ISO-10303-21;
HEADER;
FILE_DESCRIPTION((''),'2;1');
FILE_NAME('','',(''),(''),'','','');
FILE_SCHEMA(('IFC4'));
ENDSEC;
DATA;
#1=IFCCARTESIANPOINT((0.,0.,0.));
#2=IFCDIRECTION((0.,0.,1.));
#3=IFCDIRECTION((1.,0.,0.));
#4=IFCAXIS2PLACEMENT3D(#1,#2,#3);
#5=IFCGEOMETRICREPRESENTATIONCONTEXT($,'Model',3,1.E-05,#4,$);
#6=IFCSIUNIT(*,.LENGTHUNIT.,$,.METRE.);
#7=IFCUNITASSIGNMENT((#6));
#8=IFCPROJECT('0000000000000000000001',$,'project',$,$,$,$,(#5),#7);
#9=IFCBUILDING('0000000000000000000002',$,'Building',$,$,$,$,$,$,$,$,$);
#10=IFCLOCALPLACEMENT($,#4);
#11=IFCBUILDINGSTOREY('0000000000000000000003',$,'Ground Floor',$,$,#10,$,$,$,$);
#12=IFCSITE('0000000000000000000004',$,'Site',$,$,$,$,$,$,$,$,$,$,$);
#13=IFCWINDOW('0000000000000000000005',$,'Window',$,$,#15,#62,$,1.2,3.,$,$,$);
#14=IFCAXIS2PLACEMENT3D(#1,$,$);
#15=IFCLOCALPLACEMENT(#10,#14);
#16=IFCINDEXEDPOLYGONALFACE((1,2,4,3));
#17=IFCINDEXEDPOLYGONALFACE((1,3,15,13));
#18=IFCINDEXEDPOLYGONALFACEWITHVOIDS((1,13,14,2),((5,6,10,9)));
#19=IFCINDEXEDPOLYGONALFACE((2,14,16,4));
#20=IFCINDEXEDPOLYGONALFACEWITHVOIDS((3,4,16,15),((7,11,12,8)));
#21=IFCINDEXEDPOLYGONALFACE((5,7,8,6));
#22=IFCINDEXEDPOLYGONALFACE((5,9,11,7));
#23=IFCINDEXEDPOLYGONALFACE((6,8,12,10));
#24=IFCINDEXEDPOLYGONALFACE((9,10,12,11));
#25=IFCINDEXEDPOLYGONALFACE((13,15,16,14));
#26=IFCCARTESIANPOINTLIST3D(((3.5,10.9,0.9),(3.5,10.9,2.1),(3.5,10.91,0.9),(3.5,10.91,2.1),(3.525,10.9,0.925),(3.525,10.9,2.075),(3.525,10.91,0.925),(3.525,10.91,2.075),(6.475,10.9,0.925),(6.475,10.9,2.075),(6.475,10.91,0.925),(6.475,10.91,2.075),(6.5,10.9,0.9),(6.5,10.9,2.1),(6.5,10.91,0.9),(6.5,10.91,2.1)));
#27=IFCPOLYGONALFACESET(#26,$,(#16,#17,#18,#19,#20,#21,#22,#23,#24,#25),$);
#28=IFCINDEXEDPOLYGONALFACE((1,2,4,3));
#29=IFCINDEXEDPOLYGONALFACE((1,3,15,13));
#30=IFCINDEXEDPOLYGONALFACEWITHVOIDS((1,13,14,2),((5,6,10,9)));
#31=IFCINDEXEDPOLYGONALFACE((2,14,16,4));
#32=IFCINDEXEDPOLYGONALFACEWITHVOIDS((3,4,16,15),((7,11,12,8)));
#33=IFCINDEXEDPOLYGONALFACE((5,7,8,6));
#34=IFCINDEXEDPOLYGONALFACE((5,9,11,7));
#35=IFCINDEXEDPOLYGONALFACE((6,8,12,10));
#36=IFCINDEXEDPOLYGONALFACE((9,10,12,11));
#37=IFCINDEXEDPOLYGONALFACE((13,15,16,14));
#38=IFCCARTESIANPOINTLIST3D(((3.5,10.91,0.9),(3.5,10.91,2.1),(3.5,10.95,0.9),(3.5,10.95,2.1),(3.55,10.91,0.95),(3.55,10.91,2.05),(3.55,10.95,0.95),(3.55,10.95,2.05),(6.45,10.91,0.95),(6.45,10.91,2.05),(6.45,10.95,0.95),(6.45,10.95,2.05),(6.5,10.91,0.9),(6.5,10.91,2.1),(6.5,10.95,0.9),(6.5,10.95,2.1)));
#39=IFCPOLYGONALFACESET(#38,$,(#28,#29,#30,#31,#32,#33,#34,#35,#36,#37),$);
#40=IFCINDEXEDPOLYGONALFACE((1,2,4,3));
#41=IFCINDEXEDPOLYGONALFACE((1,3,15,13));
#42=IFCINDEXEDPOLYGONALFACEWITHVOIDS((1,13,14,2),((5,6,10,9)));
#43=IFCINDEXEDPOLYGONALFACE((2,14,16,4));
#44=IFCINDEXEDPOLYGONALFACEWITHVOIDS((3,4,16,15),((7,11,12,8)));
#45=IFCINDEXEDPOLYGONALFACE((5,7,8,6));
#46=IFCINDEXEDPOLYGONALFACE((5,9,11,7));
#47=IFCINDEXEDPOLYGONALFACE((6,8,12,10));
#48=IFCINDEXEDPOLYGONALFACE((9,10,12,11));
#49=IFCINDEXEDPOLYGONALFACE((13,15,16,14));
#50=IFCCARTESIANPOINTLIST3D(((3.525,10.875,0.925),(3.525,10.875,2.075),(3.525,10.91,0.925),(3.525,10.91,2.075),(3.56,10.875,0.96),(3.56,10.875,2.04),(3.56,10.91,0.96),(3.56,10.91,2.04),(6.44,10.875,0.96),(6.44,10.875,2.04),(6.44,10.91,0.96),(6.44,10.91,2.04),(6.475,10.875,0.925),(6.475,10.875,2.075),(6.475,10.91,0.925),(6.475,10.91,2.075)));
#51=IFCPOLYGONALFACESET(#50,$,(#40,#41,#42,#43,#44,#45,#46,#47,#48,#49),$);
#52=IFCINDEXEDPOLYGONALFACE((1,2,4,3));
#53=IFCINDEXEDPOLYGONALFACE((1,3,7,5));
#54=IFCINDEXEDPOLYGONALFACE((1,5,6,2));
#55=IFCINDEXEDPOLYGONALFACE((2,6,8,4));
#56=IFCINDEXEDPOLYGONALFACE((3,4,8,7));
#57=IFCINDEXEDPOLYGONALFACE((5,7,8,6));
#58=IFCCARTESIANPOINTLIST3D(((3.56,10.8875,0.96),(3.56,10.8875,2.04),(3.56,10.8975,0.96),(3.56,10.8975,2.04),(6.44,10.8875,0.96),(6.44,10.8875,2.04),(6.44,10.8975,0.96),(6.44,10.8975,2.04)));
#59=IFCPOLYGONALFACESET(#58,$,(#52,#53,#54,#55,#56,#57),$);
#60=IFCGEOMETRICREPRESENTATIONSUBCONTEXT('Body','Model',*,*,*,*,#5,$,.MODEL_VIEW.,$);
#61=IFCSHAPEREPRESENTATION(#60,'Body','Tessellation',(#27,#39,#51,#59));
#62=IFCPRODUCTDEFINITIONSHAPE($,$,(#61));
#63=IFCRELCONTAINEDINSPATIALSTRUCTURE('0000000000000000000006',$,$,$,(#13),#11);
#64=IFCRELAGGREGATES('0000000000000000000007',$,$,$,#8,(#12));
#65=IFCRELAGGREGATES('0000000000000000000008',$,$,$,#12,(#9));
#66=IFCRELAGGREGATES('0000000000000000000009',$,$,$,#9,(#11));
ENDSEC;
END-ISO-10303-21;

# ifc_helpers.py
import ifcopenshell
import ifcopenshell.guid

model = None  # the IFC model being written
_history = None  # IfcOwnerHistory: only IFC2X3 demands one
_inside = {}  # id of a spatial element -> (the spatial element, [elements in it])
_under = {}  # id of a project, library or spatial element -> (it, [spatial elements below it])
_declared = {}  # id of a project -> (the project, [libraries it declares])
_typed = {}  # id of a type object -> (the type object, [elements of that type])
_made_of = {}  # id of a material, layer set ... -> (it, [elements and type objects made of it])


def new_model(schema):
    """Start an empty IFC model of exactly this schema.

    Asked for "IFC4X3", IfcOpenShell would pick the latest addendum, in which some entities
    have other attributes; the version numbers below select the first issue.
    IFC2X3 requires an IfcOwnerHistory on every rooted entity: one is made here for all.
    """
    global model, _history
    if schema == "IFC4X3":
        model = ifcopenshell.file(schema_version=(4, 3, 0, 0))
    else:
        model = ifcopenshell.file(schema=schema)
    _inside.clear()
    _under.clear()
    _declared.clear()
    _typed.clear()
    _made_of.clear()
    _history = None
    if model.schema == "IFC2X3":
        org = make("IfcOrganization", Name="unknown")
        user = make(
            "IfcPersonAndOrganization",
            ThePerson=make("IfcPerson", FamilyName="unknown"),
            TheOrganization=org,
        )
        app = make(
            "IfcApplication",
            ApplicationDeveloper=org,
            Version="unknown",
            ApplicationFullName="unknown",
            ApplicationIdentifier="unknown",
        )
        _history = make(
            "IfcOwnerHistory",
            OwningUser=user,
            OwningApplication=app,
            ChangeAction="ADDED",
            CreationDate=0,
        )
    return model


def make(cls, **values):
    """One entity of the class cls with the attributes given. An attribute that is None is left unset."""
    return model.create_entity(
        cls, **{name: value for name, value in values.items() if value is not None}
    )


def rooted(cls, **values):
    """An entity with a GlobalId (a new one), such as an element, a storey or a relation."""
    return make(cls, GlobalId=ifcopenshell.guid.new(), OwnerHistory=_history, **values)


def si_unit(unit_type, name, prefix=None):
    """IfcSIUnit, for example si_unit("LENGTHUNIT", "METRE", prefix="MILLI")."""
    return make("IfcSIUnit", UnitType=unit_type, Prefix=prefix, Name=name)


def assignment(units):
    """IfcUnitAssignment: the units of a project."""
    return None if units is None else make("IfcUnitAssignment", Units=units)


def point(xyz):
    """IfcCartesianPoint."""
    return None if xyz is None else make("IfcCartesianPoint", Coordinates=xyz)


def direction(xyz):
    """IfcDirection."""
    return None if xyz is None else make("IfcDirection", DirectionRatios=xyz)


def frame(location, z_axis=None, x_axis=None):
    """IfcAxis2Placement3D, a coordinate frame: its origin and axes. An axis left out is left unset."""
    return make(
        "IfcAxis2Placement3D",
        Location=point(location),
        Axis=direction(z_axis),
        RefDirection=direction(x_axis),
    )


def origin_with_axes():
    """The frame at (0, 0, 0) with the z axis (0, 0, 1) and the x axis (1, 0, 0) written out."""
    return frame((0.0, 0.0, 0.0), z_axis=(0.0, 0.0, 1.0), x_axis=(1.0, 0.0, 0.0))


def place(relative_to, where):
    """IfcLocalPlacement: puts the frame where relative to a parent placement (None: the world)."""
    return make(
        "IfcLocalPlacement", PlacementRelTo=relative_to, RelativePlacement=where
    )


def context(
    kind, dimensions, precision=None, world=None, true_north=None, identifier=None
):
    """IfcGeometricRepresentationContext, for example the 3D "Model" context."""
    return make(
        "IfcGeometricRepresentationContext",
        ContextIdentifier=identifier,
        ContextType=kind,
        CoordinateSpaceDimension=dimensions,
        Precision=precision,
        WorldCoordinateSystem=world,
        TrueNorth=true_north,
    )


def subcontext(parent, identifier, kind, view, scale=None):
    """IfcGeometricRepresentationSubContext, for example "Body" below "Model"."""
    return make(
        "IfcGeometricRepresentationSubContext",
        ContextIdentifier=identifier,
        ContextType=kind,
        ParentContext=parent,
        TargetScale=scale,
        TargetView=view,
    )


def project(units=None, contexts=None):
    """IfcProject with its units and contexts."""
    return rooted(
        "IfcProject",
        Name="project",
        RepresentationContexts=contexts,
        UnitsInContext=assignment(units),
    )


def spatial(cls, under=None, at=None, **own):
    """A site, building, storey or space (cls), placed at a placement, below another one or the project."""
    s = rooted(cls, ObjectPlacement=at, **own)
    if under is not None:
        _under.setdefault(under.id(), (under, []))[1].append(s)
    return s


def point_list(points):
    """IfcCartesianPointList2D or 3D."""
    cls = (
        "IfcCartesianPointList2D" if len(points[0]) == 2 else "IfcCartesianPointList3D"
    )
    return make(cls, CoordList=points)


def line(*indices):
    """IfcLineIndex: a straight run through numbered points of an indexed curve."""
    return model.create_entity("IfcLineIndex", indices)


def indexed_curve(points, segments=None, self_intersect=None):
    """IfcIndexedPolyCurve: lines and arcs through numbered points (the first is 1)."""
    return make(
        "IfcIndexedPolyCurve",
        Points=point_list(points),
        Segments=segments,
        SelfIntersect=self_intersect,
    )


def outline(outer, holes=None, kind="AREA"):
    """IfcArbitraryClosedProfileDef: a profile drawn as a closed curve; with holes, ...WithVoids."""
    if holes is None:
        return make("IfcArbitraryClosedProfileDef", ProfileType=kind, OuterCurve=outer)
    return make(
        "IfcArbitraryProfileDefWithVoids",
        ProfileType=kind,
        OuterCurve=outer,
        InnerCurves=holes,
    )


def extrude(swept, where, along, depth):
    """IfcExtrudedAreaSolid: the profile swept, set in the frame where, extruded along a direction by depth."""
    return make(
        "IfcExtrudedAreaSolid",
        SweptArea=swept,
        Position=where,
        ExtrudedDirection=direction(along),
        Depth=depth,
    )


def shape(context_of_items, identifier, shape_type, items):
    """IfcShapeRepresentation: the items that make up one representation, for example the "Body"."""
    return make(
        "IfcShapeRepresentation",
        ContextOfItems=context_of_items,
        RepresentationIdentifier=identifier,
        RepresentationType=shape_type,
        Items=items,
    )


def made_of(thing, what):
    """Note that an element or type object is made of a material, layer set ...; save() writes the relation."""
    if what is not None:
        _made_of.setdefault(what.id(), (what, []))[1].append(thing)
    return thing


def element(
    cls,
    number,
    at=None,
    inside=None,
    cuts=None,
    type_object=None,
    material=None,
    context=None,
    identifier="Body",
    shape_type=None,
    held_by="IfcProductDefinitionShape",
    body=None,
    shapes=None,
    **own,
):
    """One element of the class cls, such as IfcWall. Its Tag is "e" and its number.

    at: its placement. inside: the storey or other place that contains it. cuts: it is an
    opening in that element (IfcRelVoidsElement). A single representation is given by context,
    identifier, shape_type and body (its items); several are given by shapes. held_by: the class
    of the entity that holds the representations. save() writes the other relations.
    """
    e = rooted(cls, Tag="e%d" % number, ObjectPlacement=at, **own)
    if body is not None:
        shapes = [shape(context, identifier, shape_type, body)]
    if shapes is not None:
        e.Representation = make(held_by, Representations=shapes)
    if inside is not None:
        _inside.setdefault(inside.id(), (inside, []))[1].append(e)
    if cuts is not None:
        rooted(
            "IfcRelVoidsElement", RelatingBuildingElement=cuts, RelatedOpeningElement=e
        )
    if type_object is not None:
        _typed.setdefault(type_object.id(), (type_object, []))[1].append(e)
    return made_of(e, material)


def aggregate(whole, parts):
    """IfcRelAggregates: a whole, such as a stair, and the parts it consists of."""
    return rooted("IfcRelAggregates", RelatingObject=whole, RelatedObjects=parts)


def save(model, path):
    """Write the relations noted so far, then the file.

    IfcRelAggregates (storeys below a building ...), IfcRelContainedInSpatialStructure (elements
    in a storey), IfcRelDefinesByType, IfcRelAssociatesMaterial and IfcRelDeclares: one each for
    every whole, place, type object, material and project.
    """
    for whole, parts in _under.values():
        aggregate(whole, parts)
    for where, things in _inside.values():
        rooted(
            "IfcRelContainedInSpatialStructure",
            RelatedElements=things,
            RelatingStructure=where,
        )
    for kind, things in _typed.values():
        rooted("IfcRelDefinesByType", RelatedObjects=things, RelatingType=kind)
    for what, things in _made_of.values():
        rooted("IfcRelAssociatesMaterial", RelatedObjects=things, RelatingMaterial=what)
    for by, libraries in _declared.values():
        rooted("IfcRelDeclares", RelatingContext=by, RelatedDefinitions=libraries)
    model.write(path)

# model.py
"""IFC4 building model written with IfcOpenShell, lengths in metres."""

from ifc_helpers import new_model, si_unit, frame, origin_with_axes, place, context, subcontext, project, spatial, line, indexed_curve, outline, extrude, element, save


model = new_model("IFC4")

# Units and contexts
model_context = context("Model", 3, precision=1e-05, world=origin_with_axes())
body_context = subcontext(model_context, "Body", "Model", "MODEL_VIEW")
ifc_project = project(units=[si_unit("LENGTHUNIT", "METRE")], contexts=[model_context])

# Site, building, storey
site = spatial("IfcSite", under=ifc_project, Name="Site")
building = spatial("IfcBuilding", under=site, Name="Building")
storey_placement = place(None, origin_with_axes())
storey = spatial("IfcBuildingStorey", under=building, at=storey_placement, Name="Ground Floor")

# Window
window_placement = place(storey_placement, frame((6.5, 11.0, 0.9), z_axis=(0.0, 0.0, 1.0), x_axis=(-1.0, 0.0, 0.0)))
element("IfcWindow", 1, at=window_placement, inside=storey, Name="Window", OverallHeight=1.2, OverallWidth=3.0, context=body_context, shape_type="SweptSolid", body=[
    extrude(outline(indexed_curve([(0.0, 0.0), (3.0, 0.0), (3.0, 1.2), (0.0, 1.2)], segments=[line(1, 2, 3, 4, 1)]), holes=[indexed_curve([(0.025, 0.025), (2.975, 0.025), (2.975, 1.175), (0.025, 1.175)], segments=[line(1, 2, 3, 4, 1)])]), frame((0.0, 0.09, 0.0), z_axis=(0.0, -1.0, 0.0), x_axis=(1.0, 0.0, 0.0)), (0.0, 0.0, -1.0), 0.01),
    extrude(outline(indexed_curve([(0.0, 0.0), (3.0, 0.0), (3.0, 1.2), (0.0, 1.2)], segments=[line(1, 2, 3, 4, 1)]), holes=[indexed_curve([(0.05, 0.05), (2.95, 0.05), (2.95, 1.15), (0.05, 1.15)], segments=[line(1, 2, 3, 4, 1)])]), frame((0.0, 0.05, 0.0), z_axis=(0.0, -1.0, 0.0), x_axis=(1.0, 0.0, 0.0)), (0.0, 0.0, -1.0), 0.04),
    extrude(outline(indexed_curve([(0.0, 0.0), (2.95, 0.0), (2.95, 1.15), (0.0, 1.15)], segments=[line(1, 2, 3, 4, 1)]), holes=[indexed_curve([(0.035, 0.035), (2.915, 0.035), (2.915, 1.115), (0.035, 1.115)], segments=[line(1, 2, 3, 4, 1)])]), frame((0.025, 0.09, 0.025), z_axis=(0.0, -1.0, 0.0), x_axis=(1.0, 0.0, 0.0)), (0.0, 0.0, -1.0), 0.035),
    extrude(outline(indexed_curve([(0.035, 0.035), (2.915, 0.035), (2.915, 1.115), (0.035, 1.115)], segments=[line(1, 2, 3, 4, 1)])), frame((0.025, 0.1025, 0.025), z_axis=(0.0, -1.0, 0.0), x_axis=(1.0, 0.0, 0.0)), (0.0, 0.0, -1.0), 0.01),
])

save(model, "model.ifc")
